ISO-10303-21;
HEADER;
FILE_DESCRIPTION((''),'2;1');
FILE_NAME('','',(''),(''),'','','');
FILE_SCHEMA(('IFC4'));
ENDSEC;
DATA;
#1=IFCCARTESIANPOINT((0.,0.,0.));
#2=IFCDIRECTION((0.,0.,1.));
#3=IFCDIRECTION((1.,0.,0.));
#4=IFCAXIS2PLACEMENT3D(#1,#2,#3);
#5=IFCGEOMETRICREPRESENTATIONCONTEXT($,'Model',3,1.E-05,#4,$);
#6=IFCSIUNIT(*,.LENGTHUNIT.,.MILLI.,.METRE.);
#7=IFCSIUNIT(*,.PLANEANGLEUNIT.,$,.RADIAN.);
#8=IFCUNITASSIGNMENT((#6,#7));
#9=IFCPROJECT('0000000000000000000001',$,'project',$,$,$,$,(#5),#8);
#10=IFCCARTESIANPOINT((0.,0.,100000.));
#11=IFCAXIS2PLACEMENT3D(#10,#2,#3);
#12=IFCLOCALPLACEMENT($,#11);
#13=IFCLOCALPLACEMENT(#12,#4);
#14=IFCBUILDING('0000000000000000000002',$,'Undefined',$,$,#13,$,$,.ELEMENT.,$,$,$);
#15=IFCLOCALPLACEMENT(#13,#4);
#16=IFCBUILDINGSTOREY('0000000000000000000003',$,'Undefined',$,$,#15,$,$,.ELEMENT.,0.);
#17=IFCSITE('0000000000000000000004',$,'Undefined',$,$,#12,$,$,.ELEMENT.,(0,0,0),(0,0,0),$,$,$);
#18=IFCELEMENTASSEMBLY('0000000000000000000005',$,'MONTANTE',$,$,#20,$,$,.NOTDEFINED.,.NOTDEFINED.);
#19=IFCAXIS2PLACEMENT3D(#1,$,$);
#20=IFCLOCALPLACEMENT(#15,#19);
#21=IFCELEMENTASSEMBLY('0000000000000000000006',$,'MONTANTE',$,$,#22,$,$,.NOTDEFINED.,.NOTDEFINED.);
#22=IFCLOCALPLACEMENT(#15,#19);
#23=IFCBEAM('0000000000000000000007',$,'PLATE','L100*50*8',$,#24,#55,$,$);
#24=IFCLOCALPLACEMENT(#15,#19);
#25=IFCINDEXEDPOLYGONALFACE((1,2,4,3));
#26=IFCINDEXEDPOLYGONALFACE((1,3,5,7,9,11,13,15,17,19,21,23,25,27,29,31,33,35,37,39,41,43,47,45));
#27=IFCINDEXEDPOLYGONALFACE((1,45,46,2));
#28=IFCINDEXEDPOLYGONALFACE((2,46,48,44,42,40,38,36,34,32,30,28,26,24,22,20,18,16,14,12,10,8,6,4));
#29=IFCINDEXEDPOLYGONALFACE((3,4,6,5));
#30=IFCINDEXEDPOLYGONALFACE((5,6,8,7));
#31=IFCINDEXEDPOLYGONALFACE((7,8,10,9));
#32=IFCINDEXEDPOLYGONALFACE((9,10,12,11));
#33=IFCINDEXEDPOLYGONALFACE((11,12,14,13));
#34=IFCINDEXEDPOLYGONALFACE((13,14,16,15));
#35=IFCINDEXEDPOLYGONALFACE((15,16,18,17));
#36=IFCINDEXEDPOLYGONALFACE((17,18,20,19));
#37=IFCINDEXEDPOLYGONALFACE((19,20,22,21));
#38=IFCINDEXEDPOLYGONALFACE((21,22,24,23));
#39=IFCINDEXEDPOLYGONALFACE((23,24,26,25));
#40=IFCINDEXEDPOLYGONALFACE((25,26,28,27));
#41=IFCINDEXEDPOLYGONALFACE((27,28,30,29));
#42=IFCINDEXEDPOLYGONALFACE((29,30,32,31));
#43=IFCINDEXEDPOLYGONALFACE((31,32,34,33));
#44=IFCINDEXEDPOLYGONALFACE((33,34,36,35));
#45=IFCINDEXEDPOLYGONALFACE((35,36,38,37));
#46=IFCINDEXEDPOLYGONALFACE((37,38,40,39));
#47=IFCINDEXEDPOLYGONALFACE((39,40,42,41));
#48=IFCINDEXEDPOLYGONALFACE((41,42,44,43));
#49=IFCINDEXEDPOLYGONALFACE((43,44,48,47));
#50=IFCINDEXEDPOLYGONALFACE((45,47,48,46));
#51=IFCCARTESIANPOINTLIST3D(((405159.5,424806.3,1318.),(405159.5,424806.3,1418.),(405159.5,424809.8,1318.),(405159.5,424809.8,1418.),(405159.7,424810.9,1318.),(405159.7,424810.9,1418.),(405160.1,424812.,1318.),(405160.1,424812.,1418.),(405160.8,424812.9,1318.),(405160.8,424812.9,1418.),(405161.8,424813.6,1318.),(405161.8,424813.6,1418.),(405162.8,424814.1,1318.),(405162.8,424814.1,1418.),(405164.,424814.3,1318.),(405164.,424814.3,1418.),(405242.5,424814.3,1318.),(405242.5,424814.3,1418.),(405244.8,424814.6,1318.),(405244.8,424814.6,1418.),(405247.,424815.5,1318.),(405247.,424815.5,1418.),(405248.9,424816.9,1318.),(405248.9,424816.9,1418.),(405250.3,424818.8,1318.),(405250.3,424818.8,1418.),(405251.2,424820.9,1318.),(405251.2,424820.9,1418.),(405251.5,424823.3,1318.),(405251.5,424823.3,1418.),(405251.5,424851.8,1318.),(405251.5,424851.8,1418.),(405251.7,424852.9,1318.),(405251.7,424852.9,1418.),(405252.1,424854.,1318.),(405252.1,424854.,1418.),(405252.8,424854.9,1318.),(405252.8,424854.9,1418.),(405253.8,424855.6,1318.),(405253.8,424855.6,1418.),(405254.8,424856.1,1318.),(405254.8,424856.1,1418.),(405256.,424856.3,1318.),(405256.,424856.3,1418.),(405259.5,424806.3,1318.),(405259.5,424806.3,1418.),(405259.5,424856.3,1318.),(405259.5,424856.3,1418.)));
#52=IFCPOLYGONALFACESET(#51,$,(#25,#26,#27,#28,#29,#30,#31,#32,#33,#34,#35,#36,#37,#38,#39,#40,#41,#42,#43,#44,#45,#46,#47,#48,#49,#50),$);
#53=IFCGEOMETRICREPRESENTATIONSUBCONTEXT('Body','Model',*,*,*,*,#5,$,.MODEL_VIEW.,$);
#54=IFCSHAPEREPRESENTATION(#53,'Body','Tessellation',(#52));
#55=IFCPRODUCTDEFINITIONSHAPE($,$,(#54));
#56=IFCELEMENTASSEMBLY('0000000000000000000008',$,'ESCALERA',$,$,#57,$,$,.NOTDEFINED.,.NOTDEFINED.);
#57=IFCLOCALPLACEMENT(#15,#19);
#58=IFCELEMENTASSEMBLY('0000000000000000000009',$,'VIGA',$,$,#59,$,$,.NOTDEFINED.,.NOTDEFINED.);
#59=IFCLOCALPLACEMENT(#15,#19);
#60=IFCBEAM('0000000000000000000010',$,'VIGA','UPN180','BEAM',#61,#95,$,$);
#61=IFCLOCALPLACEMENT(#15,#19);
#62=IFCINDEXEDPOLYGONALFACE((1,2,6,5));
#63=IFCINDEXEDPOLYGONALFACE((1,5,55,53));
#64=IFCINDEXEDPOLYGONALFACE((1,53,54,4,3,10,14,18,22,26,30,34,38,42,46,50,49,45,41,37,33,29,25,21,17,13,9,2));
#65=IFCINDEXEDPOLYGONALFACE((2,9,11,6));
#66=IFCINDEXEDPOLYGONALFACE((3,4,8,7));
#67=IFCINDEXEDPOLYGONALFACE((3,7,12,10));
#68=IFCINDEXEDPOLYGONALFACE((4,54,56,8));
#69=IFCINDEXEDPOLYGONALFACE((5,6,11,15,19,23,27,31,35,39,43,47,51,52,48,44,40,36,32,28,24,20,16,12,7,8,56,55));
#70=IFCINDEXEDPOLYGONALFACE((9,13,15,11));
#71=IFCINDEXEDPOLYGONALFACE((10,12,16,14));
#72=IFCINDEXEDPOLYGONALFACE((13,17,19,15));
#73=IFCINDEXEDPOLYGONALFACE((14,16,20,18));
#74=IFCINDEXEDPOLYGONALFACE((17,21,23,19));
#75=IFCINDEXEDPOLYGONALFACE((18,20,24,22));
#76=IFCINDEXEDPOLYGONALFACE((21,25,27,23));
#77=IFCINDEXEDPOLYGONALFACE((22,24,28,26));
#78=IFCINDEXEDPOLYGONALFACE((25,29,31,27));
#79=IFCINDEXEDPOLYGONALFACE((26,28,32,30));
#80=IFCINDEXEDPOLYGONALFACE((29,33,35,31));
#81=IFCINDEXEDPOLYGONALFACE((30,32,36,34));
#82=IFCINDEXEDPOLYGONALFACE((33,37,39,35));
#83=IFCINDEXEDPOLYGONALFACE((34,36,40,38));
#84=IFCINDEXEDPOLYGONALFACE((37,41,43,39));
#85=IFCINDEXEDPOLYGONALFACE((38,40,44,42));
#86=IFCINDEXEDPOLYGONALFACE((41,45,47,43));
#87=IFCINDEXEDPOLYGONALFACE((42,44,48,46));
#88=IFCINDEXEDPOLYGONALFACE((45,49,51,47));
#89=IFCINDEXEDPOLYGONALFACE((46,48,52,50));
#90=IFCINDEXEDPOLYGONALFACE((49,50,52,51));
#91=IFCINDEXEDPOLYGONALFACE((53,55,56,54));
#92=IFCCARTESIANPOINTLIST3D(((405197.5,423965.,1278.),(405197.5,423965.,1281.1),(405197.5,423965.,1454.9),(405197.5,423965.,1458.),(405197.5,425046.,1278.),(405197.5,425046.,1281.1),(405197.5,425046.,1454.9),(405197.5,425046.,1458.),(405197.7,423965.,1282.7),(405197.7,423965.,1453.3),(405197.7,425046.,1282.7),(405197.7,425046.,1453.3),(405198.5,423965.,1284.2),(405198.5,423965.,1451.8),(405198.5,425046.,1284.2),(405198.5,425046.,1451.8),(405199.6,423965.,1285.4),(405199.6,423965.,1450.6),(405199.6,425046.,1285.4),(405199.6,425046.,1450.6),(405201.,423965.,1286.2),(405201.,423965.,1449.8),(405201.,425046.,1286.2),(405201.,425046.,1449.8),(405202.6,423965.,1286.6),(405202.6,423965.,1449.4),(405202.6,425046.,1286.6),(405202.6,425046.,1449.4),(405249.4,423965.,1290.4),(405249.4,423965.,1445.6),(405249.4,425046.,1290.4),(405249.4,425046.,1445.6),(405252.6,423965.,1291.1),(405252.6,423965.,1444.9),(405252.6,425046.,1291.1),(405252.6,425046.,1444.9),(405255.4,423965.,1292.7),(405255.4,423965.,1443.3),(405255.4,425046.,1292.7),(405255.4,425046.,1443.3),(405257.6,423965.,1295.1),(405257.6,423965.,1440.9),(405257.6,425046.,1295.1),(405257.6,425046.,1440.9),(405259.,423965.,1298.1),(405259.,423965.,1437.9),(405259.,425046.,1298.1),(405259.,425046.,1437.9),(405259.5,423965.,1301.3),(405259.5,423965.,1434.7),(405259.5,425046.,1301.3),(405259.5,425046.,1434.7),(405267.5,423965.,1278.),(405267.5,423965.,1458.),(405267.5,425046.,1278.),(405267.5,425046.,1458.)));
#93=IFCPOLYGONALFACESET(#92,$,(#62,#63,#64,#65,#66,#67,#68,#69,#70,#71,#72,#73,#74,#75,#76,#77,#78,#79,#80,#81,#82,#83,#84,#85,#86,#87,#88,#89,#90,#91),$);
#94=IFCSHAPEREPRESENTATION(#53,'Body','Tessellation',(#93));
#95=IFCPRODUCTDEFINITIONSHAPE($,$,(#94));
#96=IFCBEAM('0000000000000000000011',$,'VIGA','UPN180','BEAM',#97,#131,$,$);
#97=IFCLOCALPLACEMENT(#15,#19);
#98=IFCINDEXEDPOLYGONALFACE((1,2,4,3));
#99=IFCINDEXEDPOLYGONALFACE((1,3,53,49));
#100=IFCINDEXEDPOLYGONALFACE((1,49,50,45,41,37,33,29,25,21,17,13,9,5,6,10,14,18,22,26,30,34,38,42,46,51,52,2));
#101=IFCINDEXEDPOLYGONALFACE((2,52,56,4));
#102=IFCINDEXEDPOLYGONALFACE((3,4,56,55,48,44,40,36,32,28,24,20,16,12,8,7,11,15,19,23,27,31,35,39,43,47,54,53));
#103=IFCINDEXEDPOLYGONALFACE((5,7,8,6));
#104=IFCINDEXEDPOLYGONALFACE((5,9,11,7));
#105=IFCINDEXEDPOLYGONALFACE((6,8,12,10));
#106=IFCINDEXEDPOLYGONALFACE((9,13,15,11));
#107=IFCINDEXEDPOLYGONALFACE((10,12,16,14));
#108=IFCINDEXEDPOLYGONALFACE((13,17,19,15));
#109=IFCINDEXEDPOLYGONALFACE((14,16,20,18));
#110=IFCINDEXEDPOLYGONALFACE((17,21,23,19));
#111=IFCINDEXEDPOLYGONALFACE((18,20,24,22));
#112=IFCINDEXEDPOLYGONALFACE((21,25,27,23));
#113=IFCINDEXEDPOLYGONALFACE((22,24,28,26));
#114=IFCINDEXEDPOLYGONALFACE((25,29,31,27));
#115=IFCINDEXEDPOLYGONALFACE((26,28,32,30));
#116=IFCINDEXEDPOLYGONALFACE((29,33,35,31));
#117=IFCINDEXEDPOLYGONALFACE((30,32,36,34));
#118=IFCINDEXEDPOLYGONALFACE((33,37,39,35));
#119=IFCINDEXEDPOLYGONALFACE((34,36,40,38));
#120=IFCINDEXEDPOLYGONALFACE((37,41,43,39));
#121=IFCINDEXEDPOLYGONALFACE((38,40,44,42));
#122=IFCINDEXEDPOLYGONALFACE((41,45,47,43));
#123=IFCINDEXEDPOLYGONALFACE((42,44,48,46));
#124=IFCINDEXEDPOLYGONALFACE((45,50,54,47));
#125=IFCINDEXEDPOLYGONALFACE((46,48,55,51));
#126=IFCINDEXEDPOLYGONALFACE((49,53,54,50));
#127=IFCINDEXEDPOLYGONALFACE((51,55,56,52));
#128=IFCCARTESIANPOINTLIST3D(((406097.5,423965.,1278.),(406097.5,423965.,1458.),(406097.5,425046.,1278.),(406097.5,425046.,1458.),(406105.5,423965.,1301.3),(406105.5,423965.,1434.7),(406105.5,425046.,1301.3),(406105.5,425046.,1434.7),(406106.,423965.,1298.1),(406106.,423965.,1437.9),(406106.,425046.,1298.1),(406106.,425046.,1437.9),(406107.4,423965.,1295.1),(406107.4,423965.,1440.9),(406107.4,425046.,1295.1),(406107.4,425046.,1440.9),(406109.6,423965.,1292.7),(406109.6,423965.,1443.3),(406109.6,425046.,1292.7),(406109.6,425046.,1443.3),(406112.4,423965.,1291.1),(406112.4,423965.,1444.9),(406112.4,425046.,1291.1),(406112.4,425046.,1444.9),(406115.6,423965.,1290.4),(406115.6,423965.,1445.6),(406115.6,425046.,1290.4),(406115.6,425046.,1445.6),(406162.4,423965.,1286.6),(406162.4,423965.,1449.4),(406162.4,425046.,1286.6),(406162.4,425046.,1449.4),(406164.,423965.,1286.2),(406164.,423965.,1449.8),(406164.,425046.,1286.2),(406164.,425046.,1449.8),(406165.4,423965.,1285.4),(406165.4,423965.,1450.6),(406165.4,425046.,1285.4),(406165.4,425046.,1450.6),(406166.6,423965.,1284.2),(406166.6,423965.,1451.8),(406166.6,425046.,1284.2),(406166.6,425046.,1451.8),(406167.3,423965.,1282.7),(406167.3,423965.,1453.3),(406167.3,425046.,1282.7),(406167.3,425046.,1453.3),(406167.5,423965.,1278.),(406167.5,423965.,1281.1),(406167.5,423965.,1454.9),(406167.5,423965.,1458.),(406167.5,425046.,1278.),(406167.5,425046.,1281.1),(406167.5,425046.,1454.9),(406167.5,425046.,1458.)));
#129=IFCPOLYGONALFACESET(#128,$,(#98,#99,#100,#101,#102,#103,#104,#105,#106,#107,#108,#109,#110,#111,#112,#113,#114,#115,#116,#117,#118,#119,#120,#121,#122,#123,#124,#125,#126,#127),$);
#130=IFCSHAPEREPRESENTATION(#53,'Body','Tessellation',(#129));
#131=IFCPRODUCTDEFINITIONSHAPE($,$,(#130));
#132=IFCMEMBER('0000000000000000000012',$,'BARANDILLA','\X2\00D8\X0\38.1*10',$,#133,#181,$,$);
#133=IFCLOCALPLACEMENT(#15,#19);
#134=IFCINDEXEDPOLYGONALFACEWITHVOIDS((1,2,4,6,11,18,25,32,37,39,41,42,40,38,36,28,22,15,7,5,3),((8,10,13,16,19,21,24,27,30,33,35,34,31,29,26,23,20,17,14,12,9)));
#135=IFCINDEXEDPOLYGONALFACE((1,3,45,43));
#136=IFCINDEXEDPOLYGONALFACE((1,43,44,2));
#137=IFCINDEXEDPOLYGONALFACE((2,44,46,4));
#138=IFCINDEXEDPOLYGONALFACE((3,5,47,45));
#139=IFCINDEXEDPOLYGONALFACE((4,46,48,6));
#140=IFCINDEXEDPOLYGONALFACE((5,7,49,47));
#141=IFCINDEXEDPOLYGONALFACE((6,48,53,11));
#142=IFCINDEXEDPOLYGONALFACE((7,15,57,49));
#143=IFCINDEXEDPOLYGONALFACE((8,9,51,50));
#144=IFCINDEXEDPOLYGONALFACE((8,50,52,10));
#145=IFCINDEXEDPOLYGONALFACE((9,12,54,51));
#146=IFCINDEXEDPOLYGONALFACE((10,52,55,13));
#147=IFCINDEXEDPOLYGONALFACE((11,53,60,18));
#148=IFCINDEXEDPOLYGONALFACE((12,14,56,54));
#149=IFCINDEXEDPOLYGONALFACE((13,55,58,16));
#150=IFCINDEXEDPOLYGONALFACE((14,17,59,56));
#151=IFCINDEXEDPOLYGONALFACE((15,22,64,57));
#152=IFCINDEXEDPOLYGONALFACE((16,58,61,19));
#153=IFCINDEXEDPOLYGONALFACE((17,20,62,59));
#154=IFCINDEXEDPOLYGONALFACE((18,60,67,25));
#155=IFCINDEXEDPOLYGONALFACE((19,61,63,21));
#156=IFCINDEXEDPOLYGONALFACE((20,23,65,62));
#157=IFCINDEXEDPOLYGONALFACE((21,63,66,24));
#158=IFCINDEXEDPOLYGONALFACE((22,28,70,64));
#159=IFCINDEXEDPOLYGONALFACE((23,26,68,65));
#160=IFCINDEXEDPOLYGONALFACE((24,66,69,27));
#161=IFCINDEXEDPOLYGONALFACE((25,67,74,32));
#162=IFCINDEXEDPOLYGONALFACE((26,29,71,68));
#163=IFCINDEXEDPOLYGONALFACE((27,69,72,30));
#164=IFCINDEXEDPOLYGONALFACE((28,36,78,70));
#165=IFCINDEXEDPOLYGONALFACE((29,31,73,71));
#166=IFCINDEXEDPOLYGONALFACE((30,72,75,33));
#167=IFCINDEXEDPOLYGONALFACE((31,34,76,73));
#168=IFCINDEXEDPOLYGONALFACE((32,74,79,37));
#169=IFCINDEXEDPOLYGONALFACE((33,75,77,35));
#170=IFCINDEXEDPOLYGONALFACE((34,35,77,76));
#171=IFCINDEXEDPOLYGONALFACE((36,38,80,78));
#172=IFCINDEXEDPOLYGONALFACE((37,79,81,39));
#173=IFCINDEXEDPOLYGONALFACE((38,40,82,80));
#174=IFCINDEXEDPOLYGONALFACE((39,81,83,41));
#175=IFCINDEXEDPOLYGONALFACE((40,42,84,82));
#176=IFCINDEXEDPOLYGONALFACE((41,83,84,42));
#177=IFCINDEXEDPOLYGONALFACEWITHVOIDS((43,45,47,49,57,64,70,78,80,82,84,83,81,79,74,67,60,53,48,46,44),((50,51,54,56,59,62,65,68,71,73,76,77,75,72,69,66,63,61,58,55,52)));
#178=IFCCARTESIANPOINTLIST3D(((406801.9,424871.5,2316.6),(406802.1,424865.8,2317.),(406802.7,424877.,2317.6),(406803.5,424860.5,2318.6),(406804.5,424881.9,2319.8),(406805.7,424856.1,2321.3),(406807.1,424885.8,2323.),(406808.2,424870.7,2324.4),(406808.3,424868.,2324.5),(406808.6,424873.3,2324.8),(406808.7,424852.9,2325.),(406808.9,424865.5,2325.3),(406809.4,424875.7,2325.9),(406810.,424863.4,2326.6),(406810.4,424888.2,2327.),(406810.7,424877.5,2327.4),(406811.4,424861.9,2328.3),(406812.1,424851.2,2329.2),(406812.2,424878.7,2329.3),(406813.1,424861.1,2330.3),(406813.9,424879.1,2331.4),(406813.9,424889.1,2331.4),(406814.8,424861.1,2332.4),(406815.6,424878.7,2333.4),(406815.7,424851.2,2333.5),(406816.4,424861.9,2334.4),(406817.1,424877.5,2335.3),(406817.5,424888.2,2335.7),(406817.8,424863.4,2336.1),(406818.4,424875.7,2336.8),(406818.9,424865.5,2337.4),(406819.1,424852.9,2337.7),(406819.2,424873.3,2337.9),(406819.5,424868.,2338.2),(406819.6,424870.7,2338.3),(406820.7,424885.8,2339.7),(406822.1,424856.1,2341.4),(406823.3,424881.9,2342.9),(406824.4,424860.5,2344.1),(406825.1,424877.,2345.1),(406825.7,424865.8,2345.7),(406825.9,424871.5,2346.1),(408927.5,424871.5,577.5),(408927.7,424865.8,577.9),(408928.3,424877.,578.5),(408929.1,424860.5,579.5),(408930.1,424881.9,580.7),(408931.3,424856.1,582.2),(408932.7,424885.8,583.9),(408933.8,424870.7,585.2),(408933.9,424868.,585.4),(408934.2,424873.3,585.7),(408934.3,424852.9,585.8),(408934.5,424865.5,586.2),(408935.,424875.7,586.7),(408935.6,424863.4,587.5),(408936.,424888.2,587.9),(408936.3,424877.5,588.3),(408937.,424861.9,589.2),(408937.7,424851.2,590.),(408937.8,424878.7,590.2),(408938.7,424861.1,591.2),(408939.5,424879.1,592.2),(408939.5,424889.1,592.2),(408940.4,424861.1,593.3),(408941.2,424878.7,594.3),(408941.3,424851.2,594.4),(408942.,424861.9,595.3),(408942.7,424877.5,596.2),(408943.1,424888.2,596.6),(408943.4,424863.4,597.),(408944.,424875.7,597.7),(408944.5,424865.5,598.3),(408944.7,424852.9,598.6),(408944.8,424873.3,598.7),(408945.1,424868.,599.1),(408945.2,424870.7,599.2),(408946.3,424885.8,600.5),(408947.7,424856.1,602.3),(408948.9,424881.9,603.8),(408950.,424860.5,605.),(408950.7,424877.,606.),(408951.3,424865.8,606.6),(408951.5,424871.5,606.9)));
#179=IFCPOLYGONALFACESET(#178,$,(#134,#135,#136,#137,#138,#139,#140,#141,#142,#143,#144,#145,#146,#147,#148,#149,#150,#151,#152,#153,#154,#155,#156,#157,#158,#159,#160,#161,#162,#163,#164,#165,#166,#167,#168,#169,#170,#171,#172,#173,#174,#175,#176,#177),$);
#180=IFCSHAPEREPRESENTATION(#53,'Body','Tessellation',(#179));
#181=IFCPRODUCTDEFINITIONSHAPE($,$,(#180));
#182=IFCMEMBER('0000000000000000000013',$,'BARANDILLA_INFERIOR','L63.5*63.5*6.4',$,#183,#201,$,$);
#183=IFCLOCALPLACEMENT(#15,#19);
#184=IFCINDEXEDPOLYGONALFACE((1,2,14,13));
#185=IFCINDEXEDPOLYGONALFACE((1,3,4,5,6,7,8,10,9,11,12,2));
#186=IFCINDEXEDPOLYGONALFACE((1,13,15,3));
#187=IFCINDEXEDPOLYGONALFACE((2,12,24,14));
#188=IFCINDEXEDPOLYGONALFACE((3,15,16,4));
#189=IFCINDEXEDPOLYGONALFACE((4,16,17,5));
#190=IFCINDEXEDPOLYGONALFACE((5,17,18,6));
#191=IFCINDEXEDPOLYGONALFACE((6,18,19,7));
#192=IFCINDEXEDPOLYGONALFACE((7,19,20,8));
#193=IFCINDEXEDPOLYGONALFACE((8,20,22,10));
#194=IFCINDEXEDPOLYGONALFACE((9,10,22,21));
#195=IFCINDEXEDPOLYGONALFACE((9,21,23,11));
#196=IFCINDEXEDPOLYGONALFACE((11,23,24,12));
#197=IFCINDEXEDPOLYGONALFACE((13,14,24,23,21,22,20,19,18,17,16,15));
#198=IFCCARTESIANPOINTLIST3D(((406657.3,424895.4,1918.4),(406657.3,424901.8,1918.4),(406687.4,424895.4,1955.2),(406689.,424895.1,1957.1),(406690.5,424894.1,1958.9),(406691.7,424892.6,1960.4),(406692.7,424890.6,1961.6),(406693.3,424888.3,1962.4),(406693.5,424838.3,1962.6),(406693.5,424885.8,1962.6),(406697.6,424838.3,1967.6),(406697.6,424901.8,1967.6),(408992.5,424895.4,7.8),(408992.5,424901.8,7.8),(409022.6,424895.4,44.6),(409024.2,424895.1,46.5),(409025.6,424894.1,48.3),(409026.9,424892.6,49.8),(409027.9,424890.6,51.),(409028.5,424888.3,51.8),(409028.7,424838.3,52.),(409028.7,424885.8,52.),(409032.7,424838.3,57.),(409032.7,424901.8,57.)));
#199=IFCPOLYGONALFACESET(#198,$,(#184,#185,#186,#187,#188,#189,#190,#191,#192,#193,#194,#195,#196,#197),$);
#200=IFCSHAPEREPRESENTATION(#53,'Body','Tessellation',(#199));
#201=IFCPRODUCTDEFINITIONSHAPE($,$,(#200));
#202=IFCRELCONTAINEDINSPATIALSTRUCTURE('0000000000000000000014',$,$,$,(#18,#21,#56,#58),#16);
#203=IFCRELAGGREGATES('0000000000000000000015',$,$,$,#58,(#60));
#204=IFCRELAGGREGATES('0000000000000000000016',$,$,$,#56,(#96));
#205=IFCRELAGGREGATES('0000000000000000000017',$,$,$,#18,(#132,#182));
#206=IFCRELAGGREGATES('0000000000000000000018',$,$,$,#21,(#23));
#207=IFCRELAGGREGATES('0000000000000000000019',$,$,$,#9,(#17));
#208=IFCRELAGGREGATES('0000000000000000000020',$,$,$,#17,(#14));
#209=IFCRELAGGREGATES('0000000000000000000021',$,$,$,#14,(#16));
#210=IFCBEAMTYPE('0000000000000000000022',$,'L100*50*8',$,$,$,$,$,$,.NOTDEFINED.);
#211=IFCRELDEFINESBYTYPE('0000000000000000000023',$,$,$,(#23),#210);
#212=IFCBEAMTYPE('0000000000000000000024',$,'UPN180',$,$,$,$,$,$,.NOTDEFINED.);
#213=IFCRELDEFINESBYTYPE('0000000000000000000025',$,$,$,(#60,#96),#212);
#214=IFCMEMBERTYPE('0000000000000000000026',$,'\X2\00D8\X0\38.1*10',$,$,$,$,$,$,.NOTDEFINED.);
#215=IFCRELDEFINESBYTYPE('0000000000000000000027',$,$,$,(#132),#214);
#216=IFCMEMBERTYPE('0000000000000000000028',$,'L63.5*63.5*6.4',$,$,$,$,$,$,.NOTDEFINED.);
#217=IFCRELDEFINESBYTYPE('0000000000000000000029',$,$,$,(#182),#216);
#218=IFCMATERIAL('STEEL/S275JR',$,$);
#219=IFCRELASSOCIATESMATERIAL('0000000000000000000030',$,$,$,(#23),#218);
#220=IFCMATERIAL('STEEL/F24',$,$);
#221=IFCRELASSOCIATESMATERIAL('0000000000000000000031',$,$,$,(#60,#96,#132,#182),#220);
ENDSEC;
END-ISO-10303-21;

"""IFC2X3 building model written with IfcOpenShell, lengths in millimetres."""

from ifc_helpers import new_model, si_unit, frame, origin_with_axes, origin_2d_with_axis, place, context, subcontext, project, spatial, hollow_circle, l_section, u_section, extrude, clip, halfspace, material, type_object, element, aggregate, save


model = new_model("IFC2X3")

# Units and contexts
model_context = context("Model", 3, precision=1e-05, world=origin_with_axes())
body_context = subcontext(model_context, "Body", "Model", "MODEL_VIEW")
ifc_project = project(units=[si_unit("LENGTHUNIT", "METRE", prefix="MILLI"), si_unit("PLANEANGLEUNIT", "RADIAN")], contexts=[model_context])

# Site, building, storey
site_placement = place(None, frame((0.0, 0.0, 100000.0), z_axis=(0.0, 0.0, 1.0), x_axis=(1.0, 0.0, 0.0)))
site = spatial("IfcSite", under=ifc_project, at=site_placement, Name="Undefined", CompositionType="ELEMENT", RefLatitude=(0, 0, 0), RefLongitude=(0, 0, 0))
building_placement = place(site_placement, origin_with_axes())
building = spatial("IfcBuilding", under=site, at=building_placement, Name="Undefined", CompositionType="ELEMENT")
storey_placement = place(building_placement, origin_with_axes())
storey = spatial("IfcBuildingStorey", under=building, at=storey_placement, Name="Undefined", CompositionType="ELEMENT", Elevation=0.0)

# Element assembly
assembly_1_placement = place(storey_placement, origin_with_axes())
assembly_1 = element("IfcElementAssembly", 1, at=assembly_1_placement, inside=storey, Name="MONTANTE", AssemblyPlace="NOTDEFINED", PredefinedType="NOTDEFINED")
ifc_material_1 = material(Name="STEEL/F24")

# Element assembly
assembly_2_placement = place(storey_placement, origin_with_axes())
assembly_2 = element("IfcElementAssembly", 2, at=assembly_2_placement, inside=storey, Name="MONTANTE", AssemblyPlace="NOTDEFINED", PredefinedType="NOTDEFINED")
ifc_material_2 = material(Name="STEEL/S275JR")

# Beam
beam_type_1 = type_object("IfcBeamType", Name="L100*50*8", PredefinedType="NOTDEFINED")
beam_1_placement = place(assembly_2_placement, frame((405209.5, 424831.3, 1418.0), z_axis=(-1.0, 0.0, 0.0), x_axis=(0.0, 0.0, -1.0)))
beam_1 = element("IfcBeam", 3, at=beam_1_placement, type_object=beam_type_1, material=ifc_material_2, Name="PLATE", Description="L100*50*8", context=body_context, shape_type="SweptSolid", body=[
    extrude(l_section(Depth=100.0, Width=50.0, Thickness=8.0, FilletRadius=9.0, EdgeRadius=4.5, at=origin_2d_with_axis()), frame((100.0, 0.0, 0.0), z_axis=(-1.0, 0.0, 0.0), x_axis=(0.0, -1.0, 0.0)), (0.0, 0.0, 1.0), 100.0),
])

# Element assemblies, beam
assembly_3_placement = place(storey_placement, origin_with_axes())
assembly_3 = element("IfcElementAssembly", 4, at=assembly_3_placement, inside=storey, Name="ESCALERA", AssemblyPlace="NOTDEFINED", PredefinedType="NOTDEFINED")
beam_type_2 = type_object("IfcBeamType", Name="UPN180", PredefinedType="NOTDEFINED")
assembly_4_placement = place(storey_placement, origin_with_axes())
assembly_4 = element("IfcElementAssembly", 5, at=assembly_4_placement, inside=storey, Name="VIGA", AssemblyPlace="NOTDEFINED", PredefinedType="NOTDEFINED")
beam_2_placement = place(assembly_4_placement, frame((405232.5, 425046.0, 1368.0), z_axis=(0.0, 0.0, 1.0), x_axis=(0.0, -1.0, 0.0)))
beam_2 = element("IfcBeam", 6, at=beam_2_placement, type_object=beam_type_2, material=ifc_material_1, Name="VIGA", Description="UPN180", ObjectType="BEAM", context=body_context, shape_type="SweptSolid", body=[
    extrude(u_section(Depth=180.0, FlangeWidth=70.0, WebThickness=8.0, FlangeThickness=11.0, FilletRadius=11.0, EdgeRadius=5.5, FlangeSlope=0.07983, at=origin_2d_with_axis()), frame((1081.0, 0.0, 0.0), z_axis=(-1.0, 0.0, 0.0), x_axis=(0.0, -1.0, 0.0)), (0.0, 0.0, 1.0), 1081.0),
])
aggregate(assembly_4, [beam_2])

# Beam
beam_3_placement = place(assembly_3_placement, frame((406132.5, 425046.0, 1368.0), z_axis=(0.0, 0.0, -1.0), x_axis=(0.0, -1.0, 0.0)))
beam_3 = element("IfcBeam", 7, at=beam_3_placement, type_object=beam_type_2, material=ifc_material_1, Name="VIGA", Description="UPN180", ObjectType="BEAM", context=body_context, shape_type="SweptSolid", body=[
    extrude(u_section(Depth=180.0, FlangeWidth=70.0, WebThickness=8.0, FlangeThickness=11.0, FilletRadius=11.0, EdgeRadius=5.5, FlangeSlope=0.07983, at=origin_2d_with_axis()), frame((1081.0, 0.0, 0.0), z_axis=(-1.0, 0.0, 0.0), x_axis=(0.0, -1.0, 0.0)), (0.0, 0.0, 1.0), 1081.0),
])
aggregate(assembly_3, [beam_3])

# Members
member_type_1 = type_object("IfcMemberType", Name="Ø38.1*10", PredefinedType="NOTDEFINED")
member_1_placement = place(assembly_1_placement, frame((406813.9, 424870.0, 2331.4), z_axis=(-0.633238, 0.0, -0.773957), x_axis=(0.773957, 0.0, -0.633238)))
member_1 = element("IfcMember", 8, at=member_1_placement, type_object=member_type_1, material=ifc_material_1, Name="BARANDILLA", Description="Ø38.1*10", context=body_context, shape_type="Clipping", body=[
    clip(clip(extrude(hollow_circle(Radius=19.1, WallThickness=10.0, at=origin_2d_with_axis()), frame((2784.1, 0.0, 0.0), z_axis=(-1.0, 0.0, 0.0), x_axis=(0.0, -1.0, 0.0)), (0.0, 0.0, 1.0), 2821.8), halfspace(frame((2746.4, 0.0, 0.0), z_axis=(1.0, 0.0, 0.0), x_axis=(0.0, -1.0, 0.0)), False)), halfspace(frame((0.0, 0.0, 0.0), z_axis=(1.0, 0.0, 0.0), x_axis=(0.0, -1.0, 0.0)), True)),
])
member_type_2 = type_object("IfcMemberType", Name="L63.5*63.5*6.4", PredefinedType="NOTDEFINED")
member_2_placement = place(assembly_1_placement, frame((406677.5, 424870.0, 1943.0), z_axis=(0.0, -1.0, 0.0), x_axis=(0.773957, 0.0, -0.633238)))
member_2 = element("IfcMember", 9, at=member_2_placement, type_object=member_type_2, material=ifc_material_1, Name="BARANDILLA_INFERIOR", Description="L63.5*63.5*6.4", context=body_context, shape_type="SweptSolid", body=[
    extrude(l_section(Depth=63.5, Width=63.5, Thickness=6.4, FilletRadius=9.6, at=origin_2d_with_axis()), frame((3017.2, 0.0, 0.0), z_axis=(-1.0, 0.0, 0.0), x_axis=(0.0, -1.0, 0.0)), (0.0, 0.0, 1.0), 3017.2),
])
aggregate(assembly_1, [member_1, member_2])

aggregate(assembly_2, [beam_1])

save(model, "model.ifc")
